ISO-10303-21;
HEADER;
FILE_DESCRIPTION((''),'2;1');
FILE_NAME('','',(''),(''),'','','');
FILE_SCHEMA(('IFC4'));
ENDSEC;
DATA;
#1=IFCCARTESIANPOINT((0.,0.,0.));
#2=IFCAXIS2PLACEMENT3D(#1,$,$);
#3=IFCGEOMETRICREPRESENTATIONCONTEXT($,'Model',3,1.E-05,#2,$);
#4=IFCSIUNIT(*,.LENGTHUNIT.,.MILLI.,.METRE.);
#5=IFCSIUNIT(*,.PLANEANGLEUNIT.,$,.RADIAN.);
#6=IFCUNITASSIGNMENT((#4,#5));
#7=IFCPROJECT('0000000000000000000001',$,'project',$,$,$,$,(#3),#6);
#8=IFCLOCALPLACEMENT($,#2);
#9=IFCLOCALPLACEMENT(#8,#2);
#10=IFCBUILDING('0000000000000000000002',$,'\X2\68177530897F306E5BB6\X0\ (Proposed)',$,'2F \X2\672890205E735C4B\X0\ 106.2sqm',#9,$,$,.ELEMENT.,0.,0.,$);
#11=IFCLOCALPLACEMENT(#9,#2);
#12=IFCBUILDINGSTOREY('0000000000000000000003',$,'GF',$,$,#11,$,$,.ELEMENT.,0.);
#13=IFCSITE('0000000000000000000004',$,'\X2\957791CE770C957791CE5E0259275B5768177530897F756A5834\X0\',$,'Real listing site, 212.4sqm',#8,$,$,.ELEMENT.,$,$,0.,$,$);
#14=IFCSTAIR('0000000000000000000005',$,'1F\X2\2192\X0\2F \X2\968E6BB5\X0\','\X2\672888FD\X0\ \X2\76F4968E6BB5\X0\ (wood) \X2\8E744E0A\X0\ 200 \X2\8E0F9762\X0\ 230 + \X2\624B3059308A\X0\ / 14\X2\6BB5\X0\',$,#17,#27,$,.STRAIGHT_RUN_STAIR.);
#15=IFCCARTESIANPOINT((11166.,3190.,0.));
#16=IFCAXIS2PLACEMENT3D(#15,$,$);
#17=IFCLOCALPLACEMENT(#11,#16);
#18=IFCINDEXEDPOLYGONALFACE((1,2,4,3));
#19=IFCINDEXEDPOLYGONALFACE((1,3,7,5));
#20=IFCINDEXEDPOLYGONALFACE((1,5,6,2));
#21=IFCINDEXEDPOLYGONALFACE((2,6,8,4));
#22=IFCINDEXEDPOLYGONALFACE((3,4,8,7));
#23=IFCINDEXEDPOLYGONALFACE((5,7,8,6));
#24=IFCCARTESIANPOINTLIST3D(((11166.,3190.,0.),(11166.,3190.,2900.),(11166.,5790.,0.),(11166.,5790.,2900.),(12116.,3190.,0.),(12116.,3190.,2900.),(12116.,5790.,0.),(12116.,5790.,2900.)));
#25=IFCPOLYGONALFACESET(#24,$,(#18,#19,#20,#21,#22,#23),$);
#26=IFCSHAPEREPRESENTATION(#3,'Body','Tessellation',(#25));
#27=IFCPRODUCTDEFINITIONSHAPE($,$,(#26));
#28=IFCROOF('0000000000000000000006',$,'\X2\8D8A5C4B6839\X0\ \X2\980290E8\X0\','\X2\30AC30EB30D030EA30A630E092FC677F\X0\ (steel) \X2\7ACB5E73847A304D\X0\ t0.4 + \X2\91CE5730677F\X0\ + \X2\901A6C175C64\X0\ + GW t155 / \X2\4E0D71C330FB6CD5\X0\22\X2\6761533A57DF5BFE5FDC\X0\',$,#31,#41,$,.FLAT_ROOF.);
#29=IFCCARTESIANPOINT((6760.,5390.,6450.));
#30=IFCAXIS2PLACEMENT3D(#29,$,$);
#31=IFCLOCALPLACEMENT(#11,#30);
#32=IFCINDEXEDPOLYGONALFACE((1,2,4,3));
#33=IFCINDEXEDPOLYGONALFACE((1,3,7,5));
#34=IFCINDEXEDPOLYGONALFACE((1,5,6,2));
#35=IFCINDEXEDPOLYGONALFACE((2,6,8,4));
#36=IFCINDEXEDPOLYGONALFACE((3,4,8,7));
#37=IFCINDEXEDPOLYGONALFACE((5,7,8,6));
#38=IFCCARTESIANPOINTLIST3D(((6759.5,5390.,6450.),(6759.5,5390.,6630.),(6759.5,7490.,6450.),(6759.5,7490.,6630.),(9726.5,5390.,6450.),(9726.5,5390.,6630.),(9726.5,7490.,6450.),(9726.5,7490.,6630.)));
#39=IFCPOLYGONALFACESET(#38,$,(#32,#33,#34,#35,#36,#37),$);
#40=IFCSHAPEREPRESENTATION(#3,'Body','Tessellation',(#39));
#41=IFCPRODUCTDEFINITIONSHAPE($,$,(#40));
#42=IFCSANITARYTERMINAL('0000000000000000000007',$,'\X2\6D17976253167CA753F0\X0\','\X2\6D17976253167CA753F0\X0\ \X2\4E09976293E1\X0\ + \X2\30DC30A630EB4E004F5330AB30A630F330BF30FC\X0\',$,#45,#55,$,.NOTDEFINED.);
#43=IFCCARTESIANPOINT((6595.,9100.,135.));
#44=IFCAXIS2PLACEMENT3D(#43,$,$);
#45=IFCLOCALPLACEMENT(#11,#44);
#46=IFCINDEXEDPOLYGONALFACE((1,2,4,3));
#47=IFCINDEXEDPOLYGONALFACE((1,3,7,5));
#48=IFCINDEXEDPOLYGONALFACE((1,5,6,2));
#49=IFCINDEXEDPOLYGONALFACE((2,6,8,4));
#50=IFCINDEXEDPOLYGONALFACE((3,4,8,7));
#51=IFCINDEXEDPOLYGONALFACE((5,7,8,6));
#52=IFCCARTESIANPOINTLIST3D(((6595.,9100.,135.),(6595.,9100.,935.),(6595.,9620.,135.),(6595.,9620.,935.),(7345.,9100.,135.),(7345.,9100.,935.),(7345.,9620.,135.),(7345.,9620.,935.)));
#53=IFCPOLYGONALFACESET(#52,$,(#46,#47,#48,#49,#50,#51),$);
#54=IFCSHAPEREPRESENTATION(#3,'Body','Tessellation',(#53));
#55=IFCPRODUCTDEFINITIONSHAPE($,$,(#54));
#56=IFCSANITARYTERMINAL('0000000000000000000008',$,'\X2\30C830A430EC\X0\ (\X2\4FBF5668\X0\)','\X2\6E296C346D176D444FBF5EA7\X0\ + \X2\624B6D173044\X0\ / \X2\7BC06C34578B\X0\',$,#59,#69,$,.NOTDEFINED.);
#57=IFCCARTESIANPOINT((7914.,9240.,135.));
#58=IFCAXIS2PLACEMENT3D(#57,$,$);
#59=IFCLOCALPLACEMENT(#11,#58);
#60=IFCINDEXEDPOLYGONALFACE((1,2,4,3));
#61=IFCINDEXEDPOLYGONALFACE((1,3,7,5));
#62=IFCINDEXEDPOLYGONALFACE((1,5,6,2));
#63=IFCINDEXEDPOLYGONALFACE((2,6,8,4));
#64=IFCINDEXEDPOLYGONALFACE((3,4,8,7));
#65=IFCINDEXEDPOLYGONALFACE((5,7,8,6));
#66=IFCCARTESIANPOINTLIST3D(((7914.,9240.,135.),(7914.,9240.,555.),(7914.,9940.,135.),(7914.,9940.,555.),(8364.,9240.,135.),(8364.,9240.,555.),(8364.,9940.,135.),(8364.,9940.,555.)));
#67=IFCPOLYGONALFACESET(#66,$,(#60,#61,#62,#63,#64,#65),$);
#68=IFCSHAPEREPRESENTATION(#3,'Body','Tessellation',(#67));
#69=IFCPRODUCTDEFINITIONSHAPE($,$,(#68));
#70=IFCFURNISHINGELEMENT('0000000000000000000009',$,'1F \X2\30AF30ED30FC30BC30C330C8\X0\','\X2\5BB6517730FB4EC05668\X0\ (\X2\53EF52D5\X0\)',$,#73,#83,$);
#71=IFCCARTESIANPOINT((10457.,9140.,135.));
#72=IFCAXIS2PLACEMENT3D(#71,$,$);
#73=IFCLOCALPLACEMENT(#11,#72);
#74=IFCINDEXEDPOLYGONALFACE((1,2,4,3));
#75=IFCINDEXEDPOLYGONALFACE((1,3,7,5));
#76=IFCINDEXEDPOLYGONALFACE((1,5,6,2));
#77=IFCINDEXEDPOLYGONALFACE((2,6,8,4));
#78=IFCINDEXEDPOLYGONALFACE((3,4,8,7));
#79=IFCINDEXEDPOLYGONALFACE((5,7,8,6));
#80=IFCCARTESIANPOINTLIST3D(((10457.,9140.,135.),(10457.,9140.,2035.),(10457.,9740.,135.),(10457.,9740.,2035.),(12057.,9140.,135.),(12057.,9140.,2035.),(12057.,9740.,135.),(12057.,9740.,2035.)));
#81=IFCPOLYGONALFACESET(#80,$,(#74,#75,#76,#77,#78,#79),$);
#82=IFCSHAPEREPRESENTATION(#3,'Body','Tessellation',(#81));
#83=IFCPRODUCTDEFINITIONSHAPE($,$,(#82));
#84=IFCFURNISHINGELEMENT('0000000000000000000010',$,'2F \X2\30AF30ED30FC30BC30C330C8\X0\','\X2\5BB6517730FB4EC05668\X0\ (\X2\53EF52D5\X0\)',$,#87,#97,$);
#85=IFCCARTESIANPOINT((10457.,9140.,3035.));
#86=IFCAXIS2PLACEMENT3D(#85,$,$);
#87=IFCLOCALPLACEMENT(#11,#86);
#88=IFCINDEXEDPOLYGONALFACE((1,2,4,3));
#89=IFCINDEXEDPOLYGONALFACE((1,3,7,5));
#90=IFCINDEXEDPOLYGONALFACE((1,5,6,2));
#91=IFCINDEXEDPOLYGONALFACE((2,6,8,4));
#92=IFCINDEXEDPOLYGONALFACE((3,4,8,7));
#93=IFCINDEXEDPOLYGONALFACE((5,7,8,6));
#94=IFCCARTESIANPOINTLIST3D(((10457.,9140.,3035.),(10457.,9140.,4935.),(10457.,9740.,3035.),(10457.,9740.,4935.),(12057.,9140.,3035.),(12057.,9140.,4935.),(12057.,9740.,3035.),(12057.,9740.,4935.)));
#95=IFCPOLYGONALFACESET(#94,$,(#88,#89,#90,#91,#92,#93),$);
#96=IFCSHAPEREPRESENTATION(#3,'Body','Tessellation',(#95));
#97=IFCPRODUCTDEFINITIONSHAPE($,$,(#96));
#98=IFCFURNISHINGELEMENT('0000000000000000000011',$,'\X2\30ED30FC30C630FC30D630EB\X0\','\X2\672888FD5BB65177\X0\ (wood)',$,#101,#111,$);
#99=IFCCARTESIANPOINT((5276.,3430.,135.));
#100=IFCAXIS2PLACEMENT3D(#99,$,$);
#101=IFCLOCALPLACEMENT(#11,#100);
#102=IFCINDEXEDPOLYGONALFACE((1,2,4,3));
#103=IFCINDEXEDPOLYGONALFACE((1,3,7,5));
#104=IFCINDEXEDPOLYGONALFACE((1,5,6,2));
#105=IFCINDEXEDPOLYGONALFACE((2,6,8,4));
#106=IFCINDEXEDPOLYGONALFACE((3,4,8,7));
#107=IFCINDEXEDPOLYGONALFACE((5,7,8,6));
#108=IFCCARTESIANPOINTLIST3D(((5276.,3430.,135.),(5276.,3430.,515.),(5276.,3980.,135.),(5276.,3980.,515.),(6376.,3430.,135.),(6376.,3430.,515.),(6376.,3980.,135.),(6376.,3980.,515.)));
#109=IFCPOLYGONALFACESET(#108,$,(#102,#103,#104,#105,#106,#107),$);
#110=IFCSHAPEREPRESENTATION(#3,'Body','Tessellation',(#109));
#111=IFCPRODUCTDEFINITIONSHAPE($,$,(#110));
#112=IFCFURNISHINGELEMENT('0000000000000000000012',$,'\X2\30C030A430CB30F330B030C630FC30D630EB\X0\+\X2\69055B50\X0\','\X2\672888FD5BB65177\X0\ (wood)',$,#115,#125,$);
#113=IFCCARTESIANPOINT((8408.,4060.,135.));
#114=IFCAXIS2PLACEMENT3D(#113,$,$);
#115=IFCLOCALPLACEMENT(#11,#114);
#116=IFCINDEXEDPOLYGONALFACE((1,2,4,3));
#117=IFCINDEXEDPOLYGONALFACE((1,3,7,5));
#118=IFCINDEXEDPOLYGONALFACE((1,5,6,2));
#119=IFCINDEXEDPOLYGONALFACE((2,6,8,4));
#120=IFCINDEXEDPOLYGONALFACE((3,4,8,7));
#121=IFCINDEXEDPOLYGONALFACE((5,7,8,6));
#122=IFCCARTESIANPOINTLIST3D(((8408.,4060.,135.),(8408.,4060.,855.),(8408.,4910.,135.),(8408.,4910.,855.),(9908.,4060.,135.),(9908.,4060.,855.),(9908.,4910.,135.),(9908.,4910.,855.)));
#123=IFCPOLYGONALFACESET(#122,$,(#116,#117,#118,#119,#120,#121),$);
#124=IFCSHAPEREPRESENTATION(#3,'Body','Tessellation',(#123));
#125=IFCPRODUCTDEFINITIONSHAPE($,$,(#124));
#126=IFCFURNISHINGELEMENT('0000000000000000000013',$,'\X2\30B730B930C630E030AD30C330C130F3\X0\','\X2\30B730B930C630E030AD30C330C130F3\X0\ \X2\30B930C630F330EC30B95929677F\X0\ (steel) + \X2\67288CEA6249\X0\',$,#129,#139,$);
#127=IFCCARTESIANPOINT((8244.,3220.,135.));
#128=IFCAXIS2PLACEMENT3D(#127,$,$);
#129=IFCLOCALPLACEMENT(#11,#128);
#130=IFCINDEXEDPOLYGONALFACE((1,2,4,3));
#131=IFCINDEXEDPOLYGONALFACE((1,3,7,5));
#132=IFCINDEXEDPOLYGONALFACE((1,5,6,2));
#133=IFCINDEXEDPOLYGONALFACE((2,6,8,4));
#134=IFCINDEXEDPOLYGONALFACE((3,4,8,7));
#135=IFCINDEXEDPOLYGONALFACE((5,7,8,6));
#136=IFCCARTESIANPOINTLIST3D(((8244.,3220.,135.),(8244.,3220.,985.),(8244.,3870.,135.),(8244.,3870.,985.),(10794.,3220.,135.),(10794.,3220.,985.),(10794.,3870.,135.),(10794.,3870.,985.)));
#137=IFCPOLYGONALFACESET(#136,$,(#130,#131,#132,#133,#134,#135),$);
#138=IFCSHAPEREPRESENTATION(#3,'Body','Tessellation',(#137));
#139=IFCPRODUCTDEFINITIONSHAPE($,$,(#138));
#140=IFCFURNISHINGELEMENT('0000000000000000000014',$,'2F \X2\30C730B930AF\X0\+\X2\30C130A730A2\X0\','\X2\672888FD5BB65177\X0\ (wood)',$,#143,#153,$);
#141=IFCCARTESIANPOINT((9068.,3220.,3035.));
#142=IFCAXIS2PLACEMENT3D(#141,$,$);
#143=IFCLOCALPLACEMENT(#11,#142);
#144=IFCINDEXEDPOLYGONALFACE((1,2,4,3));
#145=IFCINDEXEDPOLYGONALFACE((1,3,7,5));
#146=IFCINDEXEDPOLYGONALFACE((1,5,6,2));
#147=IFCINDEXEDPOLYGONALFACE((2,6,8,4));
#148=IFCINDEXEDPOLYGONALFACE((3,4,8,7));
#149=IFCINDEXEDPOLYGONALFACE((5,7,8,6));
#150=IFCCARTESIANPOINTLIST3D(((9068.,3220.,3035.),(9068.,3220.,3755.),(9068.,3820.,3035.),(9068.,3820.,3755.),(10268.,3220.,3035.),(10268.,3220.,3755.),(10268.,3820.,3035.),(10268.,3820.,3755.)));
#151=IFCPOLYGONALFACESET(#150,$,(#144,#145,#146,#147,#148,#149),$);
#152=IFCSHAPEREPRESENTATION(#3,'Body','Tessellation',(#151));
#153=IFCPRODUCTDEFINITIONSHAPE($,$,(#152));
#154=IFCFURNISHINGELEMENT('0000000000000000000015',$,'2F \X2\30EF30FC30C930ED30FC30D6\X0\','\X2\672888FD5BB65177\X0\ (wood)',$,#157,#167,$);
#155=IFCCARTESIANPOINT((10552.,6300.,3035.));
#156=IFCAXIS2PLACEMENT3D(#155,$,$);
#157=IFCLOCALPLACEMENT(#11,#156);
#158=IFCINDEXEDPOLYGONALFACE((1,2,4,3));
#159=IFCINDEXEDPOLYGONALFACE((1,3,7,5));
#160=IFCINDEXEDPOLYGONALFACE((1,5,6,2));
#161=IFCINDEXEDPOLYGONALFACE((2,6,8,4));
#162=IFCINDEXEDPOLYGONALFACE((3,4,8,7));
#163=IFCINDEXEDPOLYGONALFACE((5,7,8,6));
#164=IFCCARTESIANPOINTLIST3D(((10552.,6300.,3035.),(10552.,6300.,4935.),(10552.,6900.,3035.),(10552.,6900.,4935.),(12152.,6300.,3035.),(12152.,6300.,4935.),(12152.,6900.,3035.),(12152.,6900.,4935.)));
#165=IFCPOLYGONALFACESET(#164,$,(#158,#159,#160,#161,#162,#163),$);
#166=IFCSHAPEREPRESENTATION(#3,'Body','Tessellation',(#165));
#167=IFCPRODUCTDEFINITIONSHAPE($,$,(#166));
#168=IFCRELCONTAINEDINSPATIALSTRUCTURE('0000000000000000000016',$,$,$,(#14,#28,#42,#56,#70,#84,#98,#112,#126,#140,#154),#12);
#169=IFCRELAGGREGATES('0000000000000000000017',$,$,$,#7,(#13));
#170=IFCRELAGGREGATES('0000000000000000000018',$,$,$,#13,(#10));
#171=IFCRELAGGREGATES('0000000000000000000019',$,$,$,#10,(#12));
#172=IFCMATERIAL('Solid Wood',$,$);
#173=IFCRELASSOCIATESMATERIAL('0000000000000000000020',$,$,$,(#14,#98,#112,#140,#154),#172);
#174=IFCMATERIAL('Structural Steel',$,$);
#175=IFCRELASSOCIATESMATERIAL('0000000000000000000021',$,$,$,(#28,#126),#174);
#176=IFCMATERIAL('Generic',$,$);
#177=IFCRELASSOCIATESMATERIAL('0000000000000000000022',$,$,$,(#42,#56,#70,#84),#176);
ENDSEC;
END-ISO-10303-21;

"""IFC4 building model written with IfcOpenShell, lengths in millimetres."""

from ifc_helpers import new_model, si_unit, frame, frame_2d, origin, place, context, project, spatial, rectangle, extrude, material, element, save


model = new_model("IFC4")

# Units and contexts
model_context = context("Model", 3, precision=1e-05, world=origin())
ifc_project = project(units=[si_unit("LENGTHUNIT", "METRE", prefix="MILLI"), si_unit("PLANEANGLEUNIT", "RADIAN")], contexts=[model_context])

# Site, building, storey
site_placement = place(None, origin())
site = spatial("IfcSite", under=ifc_project, at=site_placement, Name="長野県長野市大字栗田西番場", ObjectType="Real listing site, 212.4sqm", CompositionType="ELEMENT", RefElevation=0.0)
building_placement = place(site_placement, origin())
building = spatial("IfcBuilding", under=site, at=building_placement, Name="栗田西の家 (Proposed)", ObjectType="2F 木造平屋 106.2sqm", CompositionType="ELEMENT", ElevationOfRefHeight=0.0, ElevationOfTerrain=0.0)
storey_placement = place(building_placement, origin())
storey = spatial("IfcBuildingStorey", under=building, at=storey_placement, Name="GF", CompositionType="ELEMENT", Elevation=0.0)

# Shared definitions
ifc_material_1 = material(Name="Solid Wood")

# Stair
stair_placement = place(storey_placement, frame((11166.0, 3190.0, 0.0)))
element("IfcStair", 1, at=stair_placement, inside=storey, material=ifc_material_1, Name="1F→2F 階段", Description="木製 直階段 (wood) 蹴上 200 踏面 230 + 手すり / 14段", PredefinedType="STRAIGHT_RUN_STAIR", context=model_context, shape_type="SweptSolid", body=[
    extrude(rectangle(XDim=950.0, YDim=2600.0, at=frame_2d((475.0, 1300.0))), frame((11166.0, 3190.0, 0.0)), (0.0, 0.0, 1.0), 2900.0),
])

# Roof
ifc_material_2 = material(Name="Structural Steel")
roof_placement = place(storey_placement, frame((6760.0, 5390.0, 6450.0)))
element("IfcRoof", 2, at=roof_placement, inside=storey, material=ifc_material_2, Name="越屋根 頂部", Description="ガルバリウム鋼板 (steel) 立平葺き t0.4 + 野地板 + 通気層 + GW t155 / 不燃・法22条区域対応", PredefinedType="FLAT_ROOF", context=model_context, shape_type="SweptSolid", body=[
    extrude(rectangle(XDim=2967.0, YDim=2100.0, at=frame_2d((1483.0, 1050.0))), frame((6760.0, 5390.0, 6450.0)), (0.0, 0.0, 1.0), 180.0),
])

# Sanitary terminals
ifc_material_3 = material(Name="Generic")
sanitary_terminal_1_placement = place(storey_placement, frame((6595.0, 9100.0, 135.0)))
element("IfcSanitaryTerminal", 3, at=sanitary_terminal_1_placement, inside=storey, material=ifc_material_3, Name="洗面化粧台", Description="洗面化粧台 三面鏡 + ボウル一体カウンター", PredefinedType="NOTDEFINED", context=model_context, shape_type="SweptSolid", body=[
    extrude(rectangle(XDim=750.0, YDim=520.0, at=frame_2d((375.0, 260.0))), frame((6595.0, 9100.0, 135.0)), (0.0, 0.0, 1.0), 800.0),
])
sanitary_terminal_2_placement = place(storey_placement, frame((7914.0, 9240.0, 135.0)))
element("IfcSanitaryTerminal", 4, at=sanitary_terminal_2_placement, inside=storey, material=ifc_material_3, Name="トイレ (便器)", Description="温水洗浄便座 + 手洗い / 節水型", PredefinedType="NOTDEFINED", context=model_context, shape_type="SweptSolid", body=[
    extrude(rectangle(XDim=450.0, YDim=700.0, at=frame_2d((225.0, 350.0))), frame((7914.0, 9240.0, 135.0)), (0.0, 0.0, 1.0), 420.0),
])

# Furnishing elements
furnishing_1_placement = place(storey_placement, frame((10457.0, 9140.0, 135.0)))
element("IfcFurnishingElement", 5, at=furnishing_1_placement, inside=storey, material=ifc_material_3, Name="1F クローゼット", Description="家具・什器 (可動)", context=model_context, shape_type="SweptSolid", body=[
    extrude(rectangle(XDim=1600.0, YDim=600.0, at=frame_2d((800.0, 300.0))), frame((10457.0, 9140.0, 135.0)), (0.0, 0.0, 1.0), 1900.0),
])
furnishing_2_placement = place(storey_placement, frame((10457.0, 9140.0, 3035.0)))
element("IfcFurnishingElement", 6, at=furnishing_2_placement, inside=storey, material=ifc_material_3, Name="2F クローゼット", Description="家具・什器 (可動)", context=model_context, shape_type="SweptSolid", body=[
    extrude(rectangle(XDim=1600.0, YDim=600.0, at=frame_2d((800.0, 300.0))), frame((10457.0, 9140.0, 3035.0)), (0.0, 0.0, 1.0), 1900.0),
])
furnishing_3_placement = place(storey_placement, frame((5276.0, 3430.0, 135.0)))
element("IfcFurnishingElement", 7, at=furnishing_3_placement, inside=storey, material=ifc_material_1, Name="ローテーブル", Description="木製家具 (wood)", context=model_context, shape_type="SweptSolid", body=[
    extrude(rectangle(XDim=1100.0, YDim=550.0, at=frame_2d((550.0, 275.0))), frame((5276.0, 3430.0, 135.0)), (0.0, 0.0, 1.0), 380.0),
])
furnishing_4_placement = place(storey_placement, frame((8408.0, 4060.0, 135.0)))
element("IfcFurnishingElement", 8, at=furnishing_4_placement, inside=storey, material=ifc_material_1, Name="ダイニングテーブル+椅子", Description="木製家具 (wood)", context=model_context, shape_type="SweptSolid", body=[
    extrude(rectangle(XDim=1500.0, YDim=850.0, at=frame_2d((750.0, 425.0))), frame((8408.0, 4060.0, 135.0)), (0.0, 0.0, 1.0), 720.0),
])
furnishing_5_placement = place(storey_placement, frame((8244.0, 3220.0, 135.0)))
element("IfcFurnishingElement", 9, at=furnishing_5_placement, inside=storey, material=ifc_material_2, Name="システムキッチン", Description="システムキッチン ステンレス天板 (steel) + 木質扉", context=model_context, shape_type="SweptSolid", body=[
    extrude(rectangle(XDim=2550.0, YDim=650.0, at=frame_2d((1275.0, 325.0))), frame((8244.0, 3220.0, 135.0)), (0.0, 0.0, 1.0), 850.0),
])
furnishing_6_placement = place(storey_placement, frame((9068.0, 3220.0, 3035.0)))
element("IfcFurnishingElement", 10, at=furnishing_6_placement, inside=storey, material=ifc_material_1, Name="2F デスク+チェア", Description="木製家具 (wood)", context=model_context, shape_type="SweptSolid", body=[
    extrude(rectangle(XDim=1200.0, YDim=600.0, at=frame_2d((600.0, 300.0))), frame((9068.0, 3220.0, 3035.0)), (0.0, 0.0, 1.0), 720.0),
])
furnishing_7_placement = place(storey_placement, frame((10552.0, 6300.0, 3035.0)))
element("IfcFurnishingElement", 11, at=furnishing_7_placement, inside=storey, material=ifc_material_1, Name="2F ワードローブ", Description="木製家具 (wood)", context=model_context, shape_type="SweptSolid", body=[
    extrude(rectangle(XDim=1600.0, YDim=600.0, at=frame_2d((800.0, 300.0))), frame((10552.0, 6300.0, 3035.0)), (0.0, 0.0, 1.0), 1900.0),
])

save(model, "model.ifc")
